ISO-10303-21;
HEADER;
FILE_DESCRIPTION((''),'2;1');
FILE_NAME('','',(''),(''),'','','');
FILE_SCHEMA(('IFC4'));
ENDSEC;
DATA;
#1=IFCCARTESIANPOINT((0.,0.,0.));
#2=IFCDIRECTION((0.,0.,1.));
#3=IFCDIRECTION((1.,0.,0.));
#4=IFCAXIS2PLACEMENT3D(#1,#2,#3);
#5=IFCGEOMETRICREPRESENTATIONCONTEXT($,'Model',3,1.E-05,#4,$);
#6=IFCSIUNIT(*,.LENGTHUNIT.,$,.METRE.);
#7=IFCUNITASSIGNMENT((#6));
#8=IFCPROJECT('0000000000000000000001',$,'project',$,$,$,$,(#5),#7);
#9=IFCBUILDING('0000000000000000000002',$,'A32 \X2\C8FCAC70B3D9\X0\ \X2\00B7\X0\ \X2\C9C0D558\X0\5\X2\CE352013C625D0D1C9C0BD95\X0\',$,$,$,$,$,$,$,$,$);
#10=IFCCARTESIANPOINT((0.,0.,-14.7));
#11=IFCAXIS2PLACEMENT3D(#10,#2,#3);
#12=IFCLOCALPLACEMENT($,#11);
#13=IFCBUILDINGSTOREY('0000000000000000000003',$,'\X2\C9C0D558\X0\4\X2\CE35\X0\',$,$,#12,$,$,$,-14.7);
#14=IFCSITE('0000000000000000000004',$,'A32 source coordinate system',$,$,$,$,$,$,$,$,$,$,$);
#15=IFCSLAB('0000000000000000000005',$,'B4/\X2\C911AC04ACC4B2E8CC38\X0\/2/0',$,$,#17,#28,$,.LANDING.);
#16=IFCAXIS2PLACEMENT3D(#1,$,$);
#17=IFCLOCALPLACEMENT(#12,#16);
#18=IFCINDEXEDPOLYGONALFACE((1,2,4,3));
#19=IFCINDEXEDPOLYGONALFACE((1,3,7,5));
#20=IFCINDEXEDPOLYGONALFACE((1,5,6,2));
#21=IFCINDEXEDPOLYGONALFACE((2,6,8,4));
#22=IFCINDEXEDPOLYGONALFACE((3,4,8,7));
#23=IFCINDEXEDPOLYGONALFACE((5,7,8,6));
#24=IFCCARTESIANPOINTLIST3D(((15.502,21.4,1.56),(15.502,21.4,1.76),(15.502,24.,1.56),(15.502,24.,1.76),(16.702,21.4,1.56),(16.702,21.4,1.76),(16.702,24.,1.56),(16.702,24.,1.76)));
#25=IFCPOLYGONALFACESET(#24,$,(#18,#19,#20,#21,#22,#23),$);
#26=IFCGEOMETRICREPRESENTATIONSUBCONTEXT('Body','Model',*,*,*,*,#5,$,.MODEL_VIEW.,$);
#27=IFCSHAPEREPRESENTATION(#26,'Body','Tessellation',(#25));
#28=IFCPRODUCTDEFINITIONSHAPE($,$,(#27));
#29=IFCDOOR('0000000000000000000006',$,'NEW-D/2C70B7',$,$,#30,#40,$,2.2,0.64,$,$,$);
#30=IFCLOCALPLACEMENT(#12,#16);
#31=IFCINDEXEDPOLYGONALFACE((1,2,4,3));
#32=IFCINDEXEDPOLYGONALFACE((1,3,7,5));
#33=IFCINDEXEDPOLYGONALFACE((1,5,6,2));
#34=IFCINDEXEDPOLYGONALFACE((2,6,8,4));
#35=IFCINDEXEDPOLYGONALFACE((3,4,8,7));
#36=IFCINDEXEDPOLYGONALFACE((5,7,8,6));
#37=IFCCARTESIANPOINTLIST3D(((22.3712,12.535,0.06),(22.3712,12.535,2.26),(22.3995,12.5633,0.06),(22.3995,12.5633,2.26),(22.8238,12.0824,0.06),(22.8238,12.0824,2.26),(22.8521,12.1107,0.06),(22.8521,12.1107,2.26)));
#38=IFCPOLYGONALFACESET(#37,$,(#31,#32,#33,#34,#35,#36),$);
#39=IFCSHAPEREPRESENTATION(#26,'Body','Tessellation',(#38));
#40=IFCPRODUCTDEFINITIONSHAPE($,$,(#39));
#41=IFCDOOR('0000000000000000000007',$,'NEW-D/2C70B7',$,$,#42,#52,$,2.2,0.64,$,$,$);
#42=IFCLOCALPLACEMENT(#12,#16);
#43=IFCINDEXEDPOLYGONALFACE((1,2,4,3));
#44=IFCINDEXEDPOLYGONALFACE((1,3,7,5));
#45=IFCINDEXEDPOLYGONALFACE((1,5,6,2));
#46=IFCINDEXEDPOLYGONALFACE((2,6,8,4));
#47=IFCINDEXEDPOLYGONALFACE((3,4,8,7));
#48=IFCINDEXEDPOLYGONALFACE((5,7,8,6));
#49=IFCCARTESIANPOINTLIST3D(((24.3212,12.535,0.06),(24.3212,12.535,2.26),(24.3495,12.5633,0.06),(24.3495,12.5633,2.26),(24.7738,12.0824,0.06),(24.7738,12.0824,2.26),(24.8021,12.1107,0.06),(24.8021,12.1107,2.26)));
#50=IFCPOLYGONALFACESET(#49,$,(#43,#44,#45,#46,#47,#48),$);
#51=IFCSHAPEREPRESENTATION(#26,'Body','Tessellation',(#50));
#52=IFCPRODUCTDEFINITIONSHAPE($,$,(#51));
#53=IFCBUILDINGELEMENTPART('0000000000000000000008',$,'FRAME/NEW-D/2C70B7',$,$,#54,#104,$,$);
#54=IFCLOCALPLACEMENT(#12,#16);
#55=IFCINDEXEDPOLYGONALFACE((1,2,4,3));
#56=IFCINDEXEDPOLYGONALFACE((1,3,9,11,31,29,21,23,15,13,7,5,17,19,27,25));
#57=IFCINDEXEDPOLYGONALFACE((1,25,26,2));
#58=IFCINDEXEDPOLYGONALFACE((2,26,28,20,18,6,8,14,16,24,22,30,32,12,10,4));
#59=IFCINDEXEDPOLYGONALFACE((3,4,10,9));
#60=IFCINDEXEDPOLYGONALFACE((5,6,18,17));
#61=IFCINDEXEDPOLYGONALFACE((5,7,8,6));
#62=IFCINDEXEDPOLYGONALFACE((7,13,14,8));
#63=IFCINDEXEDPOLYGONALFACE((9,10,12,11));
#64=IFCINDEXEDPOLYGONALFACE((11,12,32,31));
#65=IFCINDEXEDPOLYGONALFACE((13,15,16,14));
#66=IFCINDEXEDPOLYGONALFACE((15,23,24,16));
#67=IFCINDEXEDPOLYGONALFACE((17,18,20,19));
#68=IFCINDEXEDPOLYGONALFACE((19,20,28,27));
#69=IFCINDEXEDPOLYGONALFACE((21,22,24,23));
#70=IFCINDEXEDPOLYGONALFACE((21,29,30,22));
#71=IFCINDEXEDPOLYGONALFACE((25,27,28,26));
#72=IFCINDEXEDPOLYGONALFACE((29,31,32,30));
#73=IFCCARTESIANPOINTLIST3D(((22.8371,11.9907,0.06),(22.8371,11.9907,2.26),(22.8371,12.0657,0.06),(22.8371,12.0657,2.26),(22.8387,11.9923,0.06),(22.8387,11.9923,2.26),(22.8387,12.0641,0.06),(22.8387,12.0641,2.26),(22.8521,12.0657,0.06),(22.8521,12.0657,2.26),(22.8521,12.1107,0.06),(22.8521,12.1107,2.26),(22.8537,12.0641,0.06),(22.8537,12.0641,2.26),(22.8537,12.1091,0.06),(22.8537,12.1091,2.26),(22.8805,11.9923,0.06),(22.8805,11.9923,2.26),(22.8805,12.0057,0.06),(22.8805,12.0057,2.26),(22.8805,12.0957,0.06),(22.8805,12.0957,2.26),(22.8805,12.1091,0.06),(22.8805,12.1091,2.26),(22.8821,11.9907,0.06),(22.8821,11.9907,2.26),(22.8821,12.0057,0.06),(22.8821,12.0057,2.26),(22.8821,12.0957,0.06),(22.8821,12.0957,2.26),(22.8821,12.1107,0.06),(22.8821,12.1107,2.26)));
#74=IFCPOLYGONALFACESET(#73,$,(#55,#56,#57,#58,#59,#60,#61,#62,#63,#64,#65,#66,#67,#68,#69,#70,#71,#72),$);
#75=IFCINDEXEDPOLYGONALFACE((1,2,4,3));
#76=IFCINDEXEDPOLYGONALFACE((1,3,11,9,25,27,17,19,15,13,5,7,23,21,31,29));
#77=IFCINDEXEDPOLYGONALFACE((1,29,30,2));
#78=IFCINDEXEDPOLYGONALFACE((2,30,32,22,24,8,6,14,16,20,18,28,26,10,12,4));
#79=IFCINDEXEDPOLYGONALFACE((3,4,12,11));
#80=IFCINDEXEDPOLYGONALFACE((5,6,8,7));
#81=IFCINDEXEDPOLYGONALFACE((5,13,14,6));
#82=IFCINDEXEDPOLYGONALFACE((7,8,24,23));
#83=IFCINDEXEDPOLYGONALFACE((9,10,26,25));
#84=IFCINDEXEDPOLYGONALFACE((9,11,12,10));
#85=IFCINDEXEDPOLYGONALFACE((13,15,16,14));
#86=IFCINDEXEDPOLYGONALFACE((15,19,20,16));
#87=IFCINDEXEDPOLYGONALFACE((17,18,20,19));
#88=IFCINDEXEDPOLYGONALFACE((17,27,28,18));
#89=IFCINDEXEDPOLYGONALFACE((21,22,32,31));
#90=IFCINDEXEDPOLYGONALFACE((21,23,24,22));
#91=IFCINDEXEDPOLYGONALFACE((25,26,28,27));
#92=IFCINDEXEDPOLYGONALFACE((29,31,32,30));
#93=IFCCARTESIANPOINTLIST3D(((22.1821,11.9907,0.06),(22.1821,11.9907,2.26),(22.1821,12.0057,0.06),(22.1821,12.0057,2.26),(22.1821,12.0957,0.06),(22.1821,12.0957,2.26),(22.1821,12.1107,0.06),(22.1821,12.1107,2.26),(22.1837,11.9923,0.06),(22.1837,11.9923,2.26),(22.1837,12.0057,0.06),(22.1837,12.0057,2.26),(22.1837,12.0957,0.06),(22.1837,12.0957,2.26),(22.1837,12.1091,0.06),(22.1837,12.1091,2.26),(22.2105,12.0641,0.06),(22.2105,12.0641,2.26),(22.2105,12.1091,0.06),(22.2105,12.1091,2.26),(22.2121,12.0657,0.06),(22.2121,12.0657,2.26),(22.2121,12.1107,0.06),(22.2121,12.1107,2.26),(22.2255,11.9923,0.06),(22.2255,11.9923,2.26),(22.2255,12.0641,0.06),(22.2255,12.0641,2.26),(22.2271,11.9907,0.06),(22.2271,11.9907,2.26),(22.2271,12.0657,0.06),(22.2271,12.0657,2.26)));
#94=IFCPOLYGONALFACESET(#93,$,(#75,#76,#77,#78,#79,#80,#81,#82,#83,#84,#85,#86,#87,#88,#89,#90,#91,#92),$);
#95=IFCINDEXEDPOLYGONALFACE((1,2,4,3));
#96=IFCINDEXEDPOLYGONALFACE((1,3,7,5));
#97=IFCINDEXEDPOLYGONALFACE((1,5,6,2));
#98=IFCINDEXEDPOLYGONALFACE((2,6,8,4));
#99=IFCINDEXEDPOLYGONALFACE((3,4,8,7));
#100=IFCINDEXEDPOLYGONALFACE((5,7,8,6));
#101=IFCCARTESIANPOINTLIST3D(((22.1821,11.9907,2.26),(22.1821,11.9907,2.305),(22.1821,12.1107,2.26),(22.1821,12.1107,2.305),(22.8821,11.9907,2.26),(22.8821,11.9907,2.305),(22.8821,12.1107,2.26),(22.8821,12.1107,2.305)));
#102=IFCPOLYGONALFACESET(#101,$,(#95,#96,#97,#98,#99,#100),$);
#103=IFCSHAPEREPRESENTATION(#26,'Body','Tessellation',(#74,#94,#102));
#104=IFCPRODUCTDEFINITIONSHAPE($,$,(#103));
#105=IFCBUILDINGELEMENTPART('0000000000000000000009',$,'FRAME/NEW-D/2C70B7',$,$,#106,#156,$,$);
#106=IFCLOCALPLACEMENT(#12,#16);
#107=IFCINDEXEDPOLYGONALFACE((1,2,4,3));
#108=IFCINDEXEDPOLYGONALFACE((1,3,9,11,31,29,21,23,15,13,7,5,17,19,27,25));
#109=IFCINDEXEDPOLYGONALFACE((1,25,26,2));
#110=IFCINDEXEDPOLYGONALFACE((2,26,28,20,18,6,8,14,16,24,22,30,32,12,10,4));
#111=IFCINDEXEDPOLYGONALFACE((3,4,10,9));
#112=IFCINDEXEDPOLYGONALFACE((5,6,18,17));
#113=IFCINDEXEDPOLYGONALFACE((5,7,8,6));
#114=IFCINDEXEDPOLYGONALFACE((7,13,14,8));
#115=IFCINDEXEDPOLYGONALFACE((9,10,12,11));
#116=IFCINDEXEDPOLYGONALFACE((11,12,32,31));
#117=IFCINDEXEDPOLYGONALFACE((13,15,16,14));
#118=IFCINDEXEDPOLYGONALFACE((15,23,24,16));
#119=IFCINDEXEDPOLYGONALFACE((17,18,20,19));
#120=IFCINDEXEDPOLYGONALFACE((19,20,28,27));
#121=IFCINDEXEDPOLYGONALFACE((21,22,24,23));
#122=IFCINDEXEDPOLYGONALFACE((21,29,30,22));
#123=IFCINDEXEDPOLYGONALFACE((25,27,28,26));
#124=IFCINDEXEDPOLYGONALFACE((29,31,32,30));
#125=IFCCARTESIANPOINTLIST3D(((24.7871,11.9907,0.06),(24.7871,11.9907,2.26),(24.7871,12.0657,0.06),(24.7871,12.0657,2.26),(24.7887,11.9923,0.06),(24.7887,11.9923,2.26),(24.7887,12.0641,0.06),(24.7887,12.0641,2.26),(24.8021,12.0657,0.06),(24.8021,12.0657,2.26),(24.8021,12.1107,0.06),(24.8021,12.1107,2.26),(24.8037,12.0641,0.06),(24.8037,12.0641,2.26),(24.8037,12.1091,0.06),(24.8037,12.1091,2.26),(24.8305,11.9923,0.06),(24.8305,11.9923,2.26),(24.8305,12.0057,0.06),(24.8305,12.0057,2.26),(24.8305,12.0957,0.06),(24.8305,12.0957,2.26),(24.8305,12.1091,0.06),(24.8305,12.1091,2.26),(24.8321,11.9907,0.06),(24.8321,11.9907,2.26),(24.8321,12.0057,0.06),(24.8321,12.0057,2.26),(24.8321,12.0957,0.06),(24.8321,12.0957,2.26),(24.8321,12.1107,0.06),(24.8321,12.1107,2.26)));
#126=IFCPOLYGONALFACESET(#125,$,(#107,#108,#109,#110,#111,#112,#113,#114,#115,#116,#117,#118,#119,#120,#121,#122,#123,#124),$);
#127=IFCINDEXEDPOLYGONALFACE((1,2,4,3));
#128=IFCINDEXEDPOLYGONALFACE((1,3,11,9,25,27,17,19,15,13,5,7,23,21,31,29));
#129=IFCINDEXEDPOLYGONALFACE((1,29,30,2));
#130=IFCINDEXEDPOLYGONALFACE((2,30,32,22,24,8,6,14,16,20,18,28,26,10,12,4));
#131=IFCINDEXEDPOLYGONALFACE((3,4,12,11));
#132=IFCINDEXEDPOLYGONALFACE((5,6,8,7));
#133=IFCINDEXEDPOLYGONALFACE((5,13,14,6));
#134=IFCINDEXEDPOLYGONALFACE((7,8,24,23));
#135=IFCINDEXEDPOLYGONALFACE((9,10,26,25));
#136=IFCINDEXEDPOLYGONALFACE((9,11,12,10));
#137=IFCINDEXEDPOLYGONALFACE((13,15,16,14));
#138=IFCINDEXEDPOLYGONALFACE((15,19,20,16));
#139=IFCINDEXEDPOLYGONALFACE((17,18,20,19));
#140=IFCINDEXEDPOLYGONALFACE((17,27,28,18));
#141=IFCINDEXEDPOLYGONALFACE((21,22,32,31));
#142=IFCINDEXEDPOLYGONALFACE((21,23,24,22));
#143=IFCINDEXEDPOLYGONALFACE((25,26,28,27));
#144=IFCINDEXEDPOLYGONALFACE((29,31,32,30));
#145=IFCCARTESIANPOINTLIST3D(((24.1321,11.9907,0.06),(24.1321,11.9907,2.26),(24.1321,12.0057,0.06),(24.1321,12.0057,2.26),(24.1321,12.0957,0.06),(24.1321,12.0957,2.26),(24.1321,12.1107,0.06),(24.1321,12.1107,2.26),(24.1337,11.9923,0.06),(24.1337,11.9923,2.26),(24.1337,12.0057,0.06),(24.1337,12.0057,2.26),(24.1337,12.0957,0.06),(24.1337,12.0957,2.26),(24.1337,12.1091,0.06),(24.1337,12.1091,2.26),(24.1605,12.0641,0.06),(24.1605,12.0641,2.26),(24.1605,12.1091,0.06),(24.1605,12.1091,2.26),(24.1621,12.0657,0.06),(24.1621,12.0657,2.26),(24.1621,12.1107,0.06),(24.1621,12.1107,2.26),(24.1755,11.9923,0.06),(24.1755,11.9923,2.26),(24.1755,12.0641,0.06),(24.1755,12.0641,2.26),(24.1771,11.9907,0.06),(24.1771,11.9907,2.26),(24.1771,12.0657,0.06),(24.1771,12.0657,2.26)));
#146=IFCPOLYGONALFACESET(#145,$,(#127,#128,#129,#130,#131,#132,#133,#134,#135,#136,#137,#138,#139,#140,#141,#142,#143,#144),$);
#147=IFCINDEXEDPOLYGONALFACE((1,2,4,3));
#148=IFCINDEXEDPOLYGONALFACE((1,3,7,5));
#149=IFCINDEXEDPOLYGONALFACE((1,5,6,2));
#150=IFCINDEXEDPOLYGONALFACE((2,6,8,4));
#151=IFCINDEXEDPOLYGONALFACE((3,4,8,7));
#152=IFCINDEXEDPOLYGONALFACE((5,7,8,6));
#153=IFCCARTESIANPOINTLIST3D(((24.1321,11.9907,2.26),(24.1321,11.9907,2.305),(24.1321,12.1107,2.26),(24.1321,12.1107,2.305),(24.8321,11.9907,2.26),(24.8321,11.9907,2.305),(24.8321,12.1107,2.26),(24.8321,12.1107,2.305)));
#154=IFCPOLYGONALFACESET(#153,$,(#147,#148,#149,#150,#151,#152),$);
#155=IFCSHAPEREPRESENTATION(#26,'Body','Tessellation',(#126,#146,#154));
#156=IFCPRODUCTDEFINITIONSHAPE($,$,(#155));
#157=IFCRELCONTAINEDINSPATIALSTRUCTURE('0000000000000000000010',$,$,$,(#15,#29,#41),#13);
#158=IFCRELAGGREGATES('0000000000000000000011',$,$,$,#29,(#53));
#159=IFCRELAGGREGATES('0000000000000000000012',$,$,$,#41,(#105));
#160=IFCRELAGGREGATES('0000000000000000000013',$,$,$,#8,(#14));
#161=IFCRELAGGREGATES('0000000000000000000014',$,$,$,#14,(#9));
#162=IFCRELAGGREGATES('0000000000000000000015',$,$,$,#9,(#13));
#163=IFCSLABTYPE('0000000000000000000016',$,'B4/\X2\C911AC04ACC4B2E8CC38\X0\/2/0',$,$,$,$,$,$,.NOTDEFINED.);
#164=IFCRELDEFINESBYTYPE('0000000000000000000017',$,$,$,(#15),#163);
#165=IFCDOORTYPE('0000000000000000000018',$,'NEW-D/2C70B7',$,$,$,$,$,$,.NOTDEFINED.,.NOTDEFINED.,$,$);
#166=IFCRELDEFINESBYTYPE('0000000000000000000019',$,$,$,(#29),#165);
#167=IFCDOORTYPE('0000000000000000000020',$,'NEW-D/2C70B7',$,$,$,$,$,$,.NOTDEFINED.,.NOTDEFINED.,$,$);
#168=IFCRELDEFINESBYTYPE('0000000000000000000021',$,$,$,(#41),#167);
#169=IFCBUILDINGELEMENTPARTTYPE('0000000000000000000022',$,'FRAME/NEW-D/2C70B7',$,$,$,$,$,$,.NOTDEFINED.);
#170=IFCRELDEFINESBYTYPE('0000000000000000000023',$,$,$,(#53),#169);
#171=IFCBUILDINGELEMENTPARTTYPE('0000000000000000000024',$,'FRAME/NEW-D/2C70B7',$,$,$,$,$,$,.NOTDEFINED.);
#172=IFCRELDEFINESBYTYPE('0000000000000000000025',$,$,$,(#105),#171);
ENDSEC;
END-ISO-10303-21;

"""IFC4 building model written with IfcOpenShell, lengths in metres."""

from ifc_helpers import new_model, si_unit, frame, origin, origin_with_axes, place, context, subcontext, project, spatial, polyline, outline, extrude, source, transform, mapped, type_object, type_shapes, element, aggregate, save


model = new_model("IFC4")

# Units and contexts
model_context = context("Model", 3, precision=1e-05, world=origin_with_axes())
body_context = subcontext(model_context, "Body", "Model", "MODEL_VIEW")
ifc_project = project(units=[si_unit("LENGTHUNIT", "METRE")], contexts=[model_context])

# Site, building, storey
site = spatial("IfcSite", under=ifc_project, Name="A32 source coordinate system")
building = spatial("IfcBuilding", under=site, Name="A32 주거동 · 지하5층–옥탑지붕")
storey_placement = place(None, frame((0.0, 0.0, -14.7), z_axis=(0.0, 0.0, 1.0), x_axis=(1.0, 0.0, 0.0)))
storey = spatial("IfcBuildingStorey", under=building, at=storey_placement, Name="지하4층", Elevation=-14.7)

# Slab
slab_type_1 = type_object("IfcSlabType", Name="B4/중간계단참/2/0", PredefinedType="NOTDEFINED")
shared_shape_1 = source(origin(), body_context, "Body", "SweptSolid", [
    extrude(outline(polyline([(16.702, 21.4), (15.502, 21.4), (15.502, 24.0), (16.702, 24.0), (16.702, 21.4)])), frame((0.0, 0.0, 1.56)), (0.0, 0.0, 1.0), 0.2),
])
type_shapes(slab_type_1, [shared_shape_1])
slab_1_placement = place(storey_placement, origin_with_axes())
element("IfcSlab", 1, at=slab_1_placement, inside=storey, type_object=slab_type_1, Name="B4/중간계단참/2/0", PredefinedType="LANDING", context=body_context, shape_type="MappedRepresentation", body=[
    mapped(shared_shape_1, transform((0.0, 0.0, 0.0), scale=1.0)),
])

# Doors
door_type_1 = type_object("IfcDoorType", Name="NEW-D/2C70B7", OperationType="NOTDEFINED", PredefinedType="NOTDEFINED")
shared_shape_2 = source(origin(), body_context, "Body", "SweptSolid", [
    extrude(outline(polyline([(22.8521, 12.1107), (22.8238, 12.0824), (22.3712, 12.535), (22.3995, 12.5633), (22.8521, 12.1107)])), frame((0.0, 0.0, 0.06)), (0.0, 0.0, 1.0), 2.2),
])
type_shapes(door_type_1, [shared_shape_2])
door_1_placement = place(storey_placement, origin_with_axes())
door_1 = element("IfcDoor", 2, at=door_1_placement, inside=storey, type_object=door_type_1, Name="NEW-D/2C70B7", OverallHeight=2.2, OverallWidth=0.64, context=body_context, shape_type="MappedRepresentation", body=[
    mapped(shared_shape_2, transform((0.0, 0.0, 0.0), scale=1.0)),
])
door_type_2 = type_object("IfcDoorType", Name="NEW-D/2C70B7", OperationType="NOTDEFINED", PredefinedType="NOTDEFINED")
shared_shape_3 = source(origin(), body_context, "Body", "SweptSolid", [
    extrude(outline(polyline([(24.8021, 12.1107), (24.7738, 12.0824), (24.3212, 12.535), (24.3495, 12.5633), (24.8021, 12.1107)])), frame((0.0, 0.0, 0.06)), (0.0, 0.0, 1.0), 2.2),
])
type_shapes(door_type_2, [shared_shape_3])
door_2_placement = place(storey_placement, origin_with_axes())
door_2 = element("IfcDoor", 3, at=door_2_placement, inside=storey, type_object=door_type_2, Name="NEW-D/2C70B7", OverallHeight=2.2, OverallWidth=0.64, context=body_context, shape_type="MappedRepresentation", body=[
    mapped(shared_shape_3, transform((0.0, 0.0, 0.0), scale=1.0)),
])

# Building element parts
building_element_part_type_1 = type_object("IfcBuildingElementPartType", Name="FRAME/NEW-D/2C70B7", PredefinedType="NOTDEFINED")
shared_shape_4 = source(origin(), body_context, "Body", "SweptSolid", [
    extrude(outline(polyline([(22.8537, 12.1091), (22.8537, 12.0641), (22.8387, 12.0641), (22.8387, 11.9923), (22.8805, 11.9923), (22.8805, 12.0057), (22.8821, 12.0057), (22.8821, 11.9907), (22.8371, 11.9907), (22.8371, 12.0657), (22.8521, 12.0657), (22.8521, 12.1107), (22.8821, 12.1107), (22.8821, 12.0957), (22.8805, 12.0957), (22.8805, 12.1091), (22.8537, 12.1091)])), frame((0.0, 0.0, 0.06)), (0.0, 0.0, 1.0), 2.2),
    extrude(outline(polyline([(22.1821, 12.1107), (22.2121, 12.1107), (22.2121, 12.0657), (22.2271, 12.0657), (22.2271, 11.9907), (22.1821, 11.9907), (22.1821, 12.0057), (22.1837, 12.0057), (22.1837, 11.9923), (22.2255, 11.9923), (22.2255, 12.0641), (22.2105, 12.0641), (22.2105, 12.1091), (22.1837, 12.1091), (22.1837, 12.0957), (22.1821, 12.0957), (22.1821, 12.1107)])), frame((0.0, 0.0, 0.06)), (0.0, 0.0, 1.0), 2.2),
    extrude(outline(polyline([(22.8821, 11.9907), (22.8821, 12.1107), (22.1821, 12.1107), (22.1821, 11.9907), (22.8821, 11.9907)])), frame((0.0, 0.0, 2.26)), (0.0, 0.0, 1.0), 0.045),
])
type_shapes(building_element_part_type_1, [shared_shape_4])
building_element_part_1_placement = place(door_1_placement, origin_with_axes())
building_element_part_1 = element("IfcBuildingElementPart", 4, at=building_element_part_1_placement, type_object=building_element_part_type_1, Name="FRAME/NEW-D/2C70B7", context=body_context, shape_type="MappedRepresentation", body=[
    mapped(shared_shape_4, transform((0.0, 0.0, 0.0), scale=1.0)),
])
aggregate(door_1, [building_element_part_1])
building_element_part_type_2 = type_object("IfcBuildingElementPartType", Name="FRAME/NEW-D/2C70B7", PredefinedType="NOTDEFINED")
shared_shape_5 = source(origin(), body_context, "Body", "SweptSolid", [
    extrude(outline(polyline([(24.8037, 12.1091), (24.8037, 12.0641), (24.7887, 12.0641), (24.7887, 11.9923), (24.8305, 11.9923), (24.8305, 12.0057), (24.8321, 12.0057), (24.8321, 11.9907), (24.7871, 11.9907), (24.7871, 12.0657), (24.8021, 12.0657), (24.8021, 12.1107), (24.8321, 12.1107), (24.8321, 12.0957), (24.8305, 12.0957), (24.8305, 12.1091), (24.8037, 12.1091)])), frame((0.0, 0.0, 0.06)), (0.0, 0.0, 1.0), 2.2),
    extrude(outline(polyline([(24.1321, 12.1107), (24.1621, 12.1107), (24.1621, 12.0657), (24.1771, 12.0657), (24.1771, 11.9907), (24.1321, 11.9907), (24.1321, 12.0057), (24.1337, 12.0057), (24.1337, 11.9923), (24.1755, 11.9923), (24.1755, 12.0641), (24.1605, 12.0641), (24.1605, 12.1091), (24.1337, 12.1091), (24.1337, 12.0957), (24.1321, 12.0957), (24.1321, 12.1107)])), frame((0.0, 0.0, 0.06)), (0.0, 0.0, 1.0), 2.2),
    extrude(outline(polyline([(24.8321, 11.9907), (24.8321, 12.1107), (24.1321, 12.1107), (24.1321, 11.9907), (24.8321, 11.9907)])), frame((0.0, 0.0, 2.26)), (0.0, 0.0, 1.0), 0.045),
])
type_shapes(building_element_part_type_2, [shared_shape_5])
building_element_part_2_placement = place(door_2_placement, origin_with_axes())
building_element_part_2 = element("IfcBuildingElementPart", 5, at=building_element_part_2_placement, type_object=building_element_part_type_2, Name="FRAME/NEW-D/2C70B7", context=body_context, shape_type="MappedRepresentation", body=[
    mapped(shared_shape_5, transform((0.0, 0.0, 0.0), scale=1.0)),
])
aggregate(door_2, [building_element_part_2])

save(model, "model.ifc")
